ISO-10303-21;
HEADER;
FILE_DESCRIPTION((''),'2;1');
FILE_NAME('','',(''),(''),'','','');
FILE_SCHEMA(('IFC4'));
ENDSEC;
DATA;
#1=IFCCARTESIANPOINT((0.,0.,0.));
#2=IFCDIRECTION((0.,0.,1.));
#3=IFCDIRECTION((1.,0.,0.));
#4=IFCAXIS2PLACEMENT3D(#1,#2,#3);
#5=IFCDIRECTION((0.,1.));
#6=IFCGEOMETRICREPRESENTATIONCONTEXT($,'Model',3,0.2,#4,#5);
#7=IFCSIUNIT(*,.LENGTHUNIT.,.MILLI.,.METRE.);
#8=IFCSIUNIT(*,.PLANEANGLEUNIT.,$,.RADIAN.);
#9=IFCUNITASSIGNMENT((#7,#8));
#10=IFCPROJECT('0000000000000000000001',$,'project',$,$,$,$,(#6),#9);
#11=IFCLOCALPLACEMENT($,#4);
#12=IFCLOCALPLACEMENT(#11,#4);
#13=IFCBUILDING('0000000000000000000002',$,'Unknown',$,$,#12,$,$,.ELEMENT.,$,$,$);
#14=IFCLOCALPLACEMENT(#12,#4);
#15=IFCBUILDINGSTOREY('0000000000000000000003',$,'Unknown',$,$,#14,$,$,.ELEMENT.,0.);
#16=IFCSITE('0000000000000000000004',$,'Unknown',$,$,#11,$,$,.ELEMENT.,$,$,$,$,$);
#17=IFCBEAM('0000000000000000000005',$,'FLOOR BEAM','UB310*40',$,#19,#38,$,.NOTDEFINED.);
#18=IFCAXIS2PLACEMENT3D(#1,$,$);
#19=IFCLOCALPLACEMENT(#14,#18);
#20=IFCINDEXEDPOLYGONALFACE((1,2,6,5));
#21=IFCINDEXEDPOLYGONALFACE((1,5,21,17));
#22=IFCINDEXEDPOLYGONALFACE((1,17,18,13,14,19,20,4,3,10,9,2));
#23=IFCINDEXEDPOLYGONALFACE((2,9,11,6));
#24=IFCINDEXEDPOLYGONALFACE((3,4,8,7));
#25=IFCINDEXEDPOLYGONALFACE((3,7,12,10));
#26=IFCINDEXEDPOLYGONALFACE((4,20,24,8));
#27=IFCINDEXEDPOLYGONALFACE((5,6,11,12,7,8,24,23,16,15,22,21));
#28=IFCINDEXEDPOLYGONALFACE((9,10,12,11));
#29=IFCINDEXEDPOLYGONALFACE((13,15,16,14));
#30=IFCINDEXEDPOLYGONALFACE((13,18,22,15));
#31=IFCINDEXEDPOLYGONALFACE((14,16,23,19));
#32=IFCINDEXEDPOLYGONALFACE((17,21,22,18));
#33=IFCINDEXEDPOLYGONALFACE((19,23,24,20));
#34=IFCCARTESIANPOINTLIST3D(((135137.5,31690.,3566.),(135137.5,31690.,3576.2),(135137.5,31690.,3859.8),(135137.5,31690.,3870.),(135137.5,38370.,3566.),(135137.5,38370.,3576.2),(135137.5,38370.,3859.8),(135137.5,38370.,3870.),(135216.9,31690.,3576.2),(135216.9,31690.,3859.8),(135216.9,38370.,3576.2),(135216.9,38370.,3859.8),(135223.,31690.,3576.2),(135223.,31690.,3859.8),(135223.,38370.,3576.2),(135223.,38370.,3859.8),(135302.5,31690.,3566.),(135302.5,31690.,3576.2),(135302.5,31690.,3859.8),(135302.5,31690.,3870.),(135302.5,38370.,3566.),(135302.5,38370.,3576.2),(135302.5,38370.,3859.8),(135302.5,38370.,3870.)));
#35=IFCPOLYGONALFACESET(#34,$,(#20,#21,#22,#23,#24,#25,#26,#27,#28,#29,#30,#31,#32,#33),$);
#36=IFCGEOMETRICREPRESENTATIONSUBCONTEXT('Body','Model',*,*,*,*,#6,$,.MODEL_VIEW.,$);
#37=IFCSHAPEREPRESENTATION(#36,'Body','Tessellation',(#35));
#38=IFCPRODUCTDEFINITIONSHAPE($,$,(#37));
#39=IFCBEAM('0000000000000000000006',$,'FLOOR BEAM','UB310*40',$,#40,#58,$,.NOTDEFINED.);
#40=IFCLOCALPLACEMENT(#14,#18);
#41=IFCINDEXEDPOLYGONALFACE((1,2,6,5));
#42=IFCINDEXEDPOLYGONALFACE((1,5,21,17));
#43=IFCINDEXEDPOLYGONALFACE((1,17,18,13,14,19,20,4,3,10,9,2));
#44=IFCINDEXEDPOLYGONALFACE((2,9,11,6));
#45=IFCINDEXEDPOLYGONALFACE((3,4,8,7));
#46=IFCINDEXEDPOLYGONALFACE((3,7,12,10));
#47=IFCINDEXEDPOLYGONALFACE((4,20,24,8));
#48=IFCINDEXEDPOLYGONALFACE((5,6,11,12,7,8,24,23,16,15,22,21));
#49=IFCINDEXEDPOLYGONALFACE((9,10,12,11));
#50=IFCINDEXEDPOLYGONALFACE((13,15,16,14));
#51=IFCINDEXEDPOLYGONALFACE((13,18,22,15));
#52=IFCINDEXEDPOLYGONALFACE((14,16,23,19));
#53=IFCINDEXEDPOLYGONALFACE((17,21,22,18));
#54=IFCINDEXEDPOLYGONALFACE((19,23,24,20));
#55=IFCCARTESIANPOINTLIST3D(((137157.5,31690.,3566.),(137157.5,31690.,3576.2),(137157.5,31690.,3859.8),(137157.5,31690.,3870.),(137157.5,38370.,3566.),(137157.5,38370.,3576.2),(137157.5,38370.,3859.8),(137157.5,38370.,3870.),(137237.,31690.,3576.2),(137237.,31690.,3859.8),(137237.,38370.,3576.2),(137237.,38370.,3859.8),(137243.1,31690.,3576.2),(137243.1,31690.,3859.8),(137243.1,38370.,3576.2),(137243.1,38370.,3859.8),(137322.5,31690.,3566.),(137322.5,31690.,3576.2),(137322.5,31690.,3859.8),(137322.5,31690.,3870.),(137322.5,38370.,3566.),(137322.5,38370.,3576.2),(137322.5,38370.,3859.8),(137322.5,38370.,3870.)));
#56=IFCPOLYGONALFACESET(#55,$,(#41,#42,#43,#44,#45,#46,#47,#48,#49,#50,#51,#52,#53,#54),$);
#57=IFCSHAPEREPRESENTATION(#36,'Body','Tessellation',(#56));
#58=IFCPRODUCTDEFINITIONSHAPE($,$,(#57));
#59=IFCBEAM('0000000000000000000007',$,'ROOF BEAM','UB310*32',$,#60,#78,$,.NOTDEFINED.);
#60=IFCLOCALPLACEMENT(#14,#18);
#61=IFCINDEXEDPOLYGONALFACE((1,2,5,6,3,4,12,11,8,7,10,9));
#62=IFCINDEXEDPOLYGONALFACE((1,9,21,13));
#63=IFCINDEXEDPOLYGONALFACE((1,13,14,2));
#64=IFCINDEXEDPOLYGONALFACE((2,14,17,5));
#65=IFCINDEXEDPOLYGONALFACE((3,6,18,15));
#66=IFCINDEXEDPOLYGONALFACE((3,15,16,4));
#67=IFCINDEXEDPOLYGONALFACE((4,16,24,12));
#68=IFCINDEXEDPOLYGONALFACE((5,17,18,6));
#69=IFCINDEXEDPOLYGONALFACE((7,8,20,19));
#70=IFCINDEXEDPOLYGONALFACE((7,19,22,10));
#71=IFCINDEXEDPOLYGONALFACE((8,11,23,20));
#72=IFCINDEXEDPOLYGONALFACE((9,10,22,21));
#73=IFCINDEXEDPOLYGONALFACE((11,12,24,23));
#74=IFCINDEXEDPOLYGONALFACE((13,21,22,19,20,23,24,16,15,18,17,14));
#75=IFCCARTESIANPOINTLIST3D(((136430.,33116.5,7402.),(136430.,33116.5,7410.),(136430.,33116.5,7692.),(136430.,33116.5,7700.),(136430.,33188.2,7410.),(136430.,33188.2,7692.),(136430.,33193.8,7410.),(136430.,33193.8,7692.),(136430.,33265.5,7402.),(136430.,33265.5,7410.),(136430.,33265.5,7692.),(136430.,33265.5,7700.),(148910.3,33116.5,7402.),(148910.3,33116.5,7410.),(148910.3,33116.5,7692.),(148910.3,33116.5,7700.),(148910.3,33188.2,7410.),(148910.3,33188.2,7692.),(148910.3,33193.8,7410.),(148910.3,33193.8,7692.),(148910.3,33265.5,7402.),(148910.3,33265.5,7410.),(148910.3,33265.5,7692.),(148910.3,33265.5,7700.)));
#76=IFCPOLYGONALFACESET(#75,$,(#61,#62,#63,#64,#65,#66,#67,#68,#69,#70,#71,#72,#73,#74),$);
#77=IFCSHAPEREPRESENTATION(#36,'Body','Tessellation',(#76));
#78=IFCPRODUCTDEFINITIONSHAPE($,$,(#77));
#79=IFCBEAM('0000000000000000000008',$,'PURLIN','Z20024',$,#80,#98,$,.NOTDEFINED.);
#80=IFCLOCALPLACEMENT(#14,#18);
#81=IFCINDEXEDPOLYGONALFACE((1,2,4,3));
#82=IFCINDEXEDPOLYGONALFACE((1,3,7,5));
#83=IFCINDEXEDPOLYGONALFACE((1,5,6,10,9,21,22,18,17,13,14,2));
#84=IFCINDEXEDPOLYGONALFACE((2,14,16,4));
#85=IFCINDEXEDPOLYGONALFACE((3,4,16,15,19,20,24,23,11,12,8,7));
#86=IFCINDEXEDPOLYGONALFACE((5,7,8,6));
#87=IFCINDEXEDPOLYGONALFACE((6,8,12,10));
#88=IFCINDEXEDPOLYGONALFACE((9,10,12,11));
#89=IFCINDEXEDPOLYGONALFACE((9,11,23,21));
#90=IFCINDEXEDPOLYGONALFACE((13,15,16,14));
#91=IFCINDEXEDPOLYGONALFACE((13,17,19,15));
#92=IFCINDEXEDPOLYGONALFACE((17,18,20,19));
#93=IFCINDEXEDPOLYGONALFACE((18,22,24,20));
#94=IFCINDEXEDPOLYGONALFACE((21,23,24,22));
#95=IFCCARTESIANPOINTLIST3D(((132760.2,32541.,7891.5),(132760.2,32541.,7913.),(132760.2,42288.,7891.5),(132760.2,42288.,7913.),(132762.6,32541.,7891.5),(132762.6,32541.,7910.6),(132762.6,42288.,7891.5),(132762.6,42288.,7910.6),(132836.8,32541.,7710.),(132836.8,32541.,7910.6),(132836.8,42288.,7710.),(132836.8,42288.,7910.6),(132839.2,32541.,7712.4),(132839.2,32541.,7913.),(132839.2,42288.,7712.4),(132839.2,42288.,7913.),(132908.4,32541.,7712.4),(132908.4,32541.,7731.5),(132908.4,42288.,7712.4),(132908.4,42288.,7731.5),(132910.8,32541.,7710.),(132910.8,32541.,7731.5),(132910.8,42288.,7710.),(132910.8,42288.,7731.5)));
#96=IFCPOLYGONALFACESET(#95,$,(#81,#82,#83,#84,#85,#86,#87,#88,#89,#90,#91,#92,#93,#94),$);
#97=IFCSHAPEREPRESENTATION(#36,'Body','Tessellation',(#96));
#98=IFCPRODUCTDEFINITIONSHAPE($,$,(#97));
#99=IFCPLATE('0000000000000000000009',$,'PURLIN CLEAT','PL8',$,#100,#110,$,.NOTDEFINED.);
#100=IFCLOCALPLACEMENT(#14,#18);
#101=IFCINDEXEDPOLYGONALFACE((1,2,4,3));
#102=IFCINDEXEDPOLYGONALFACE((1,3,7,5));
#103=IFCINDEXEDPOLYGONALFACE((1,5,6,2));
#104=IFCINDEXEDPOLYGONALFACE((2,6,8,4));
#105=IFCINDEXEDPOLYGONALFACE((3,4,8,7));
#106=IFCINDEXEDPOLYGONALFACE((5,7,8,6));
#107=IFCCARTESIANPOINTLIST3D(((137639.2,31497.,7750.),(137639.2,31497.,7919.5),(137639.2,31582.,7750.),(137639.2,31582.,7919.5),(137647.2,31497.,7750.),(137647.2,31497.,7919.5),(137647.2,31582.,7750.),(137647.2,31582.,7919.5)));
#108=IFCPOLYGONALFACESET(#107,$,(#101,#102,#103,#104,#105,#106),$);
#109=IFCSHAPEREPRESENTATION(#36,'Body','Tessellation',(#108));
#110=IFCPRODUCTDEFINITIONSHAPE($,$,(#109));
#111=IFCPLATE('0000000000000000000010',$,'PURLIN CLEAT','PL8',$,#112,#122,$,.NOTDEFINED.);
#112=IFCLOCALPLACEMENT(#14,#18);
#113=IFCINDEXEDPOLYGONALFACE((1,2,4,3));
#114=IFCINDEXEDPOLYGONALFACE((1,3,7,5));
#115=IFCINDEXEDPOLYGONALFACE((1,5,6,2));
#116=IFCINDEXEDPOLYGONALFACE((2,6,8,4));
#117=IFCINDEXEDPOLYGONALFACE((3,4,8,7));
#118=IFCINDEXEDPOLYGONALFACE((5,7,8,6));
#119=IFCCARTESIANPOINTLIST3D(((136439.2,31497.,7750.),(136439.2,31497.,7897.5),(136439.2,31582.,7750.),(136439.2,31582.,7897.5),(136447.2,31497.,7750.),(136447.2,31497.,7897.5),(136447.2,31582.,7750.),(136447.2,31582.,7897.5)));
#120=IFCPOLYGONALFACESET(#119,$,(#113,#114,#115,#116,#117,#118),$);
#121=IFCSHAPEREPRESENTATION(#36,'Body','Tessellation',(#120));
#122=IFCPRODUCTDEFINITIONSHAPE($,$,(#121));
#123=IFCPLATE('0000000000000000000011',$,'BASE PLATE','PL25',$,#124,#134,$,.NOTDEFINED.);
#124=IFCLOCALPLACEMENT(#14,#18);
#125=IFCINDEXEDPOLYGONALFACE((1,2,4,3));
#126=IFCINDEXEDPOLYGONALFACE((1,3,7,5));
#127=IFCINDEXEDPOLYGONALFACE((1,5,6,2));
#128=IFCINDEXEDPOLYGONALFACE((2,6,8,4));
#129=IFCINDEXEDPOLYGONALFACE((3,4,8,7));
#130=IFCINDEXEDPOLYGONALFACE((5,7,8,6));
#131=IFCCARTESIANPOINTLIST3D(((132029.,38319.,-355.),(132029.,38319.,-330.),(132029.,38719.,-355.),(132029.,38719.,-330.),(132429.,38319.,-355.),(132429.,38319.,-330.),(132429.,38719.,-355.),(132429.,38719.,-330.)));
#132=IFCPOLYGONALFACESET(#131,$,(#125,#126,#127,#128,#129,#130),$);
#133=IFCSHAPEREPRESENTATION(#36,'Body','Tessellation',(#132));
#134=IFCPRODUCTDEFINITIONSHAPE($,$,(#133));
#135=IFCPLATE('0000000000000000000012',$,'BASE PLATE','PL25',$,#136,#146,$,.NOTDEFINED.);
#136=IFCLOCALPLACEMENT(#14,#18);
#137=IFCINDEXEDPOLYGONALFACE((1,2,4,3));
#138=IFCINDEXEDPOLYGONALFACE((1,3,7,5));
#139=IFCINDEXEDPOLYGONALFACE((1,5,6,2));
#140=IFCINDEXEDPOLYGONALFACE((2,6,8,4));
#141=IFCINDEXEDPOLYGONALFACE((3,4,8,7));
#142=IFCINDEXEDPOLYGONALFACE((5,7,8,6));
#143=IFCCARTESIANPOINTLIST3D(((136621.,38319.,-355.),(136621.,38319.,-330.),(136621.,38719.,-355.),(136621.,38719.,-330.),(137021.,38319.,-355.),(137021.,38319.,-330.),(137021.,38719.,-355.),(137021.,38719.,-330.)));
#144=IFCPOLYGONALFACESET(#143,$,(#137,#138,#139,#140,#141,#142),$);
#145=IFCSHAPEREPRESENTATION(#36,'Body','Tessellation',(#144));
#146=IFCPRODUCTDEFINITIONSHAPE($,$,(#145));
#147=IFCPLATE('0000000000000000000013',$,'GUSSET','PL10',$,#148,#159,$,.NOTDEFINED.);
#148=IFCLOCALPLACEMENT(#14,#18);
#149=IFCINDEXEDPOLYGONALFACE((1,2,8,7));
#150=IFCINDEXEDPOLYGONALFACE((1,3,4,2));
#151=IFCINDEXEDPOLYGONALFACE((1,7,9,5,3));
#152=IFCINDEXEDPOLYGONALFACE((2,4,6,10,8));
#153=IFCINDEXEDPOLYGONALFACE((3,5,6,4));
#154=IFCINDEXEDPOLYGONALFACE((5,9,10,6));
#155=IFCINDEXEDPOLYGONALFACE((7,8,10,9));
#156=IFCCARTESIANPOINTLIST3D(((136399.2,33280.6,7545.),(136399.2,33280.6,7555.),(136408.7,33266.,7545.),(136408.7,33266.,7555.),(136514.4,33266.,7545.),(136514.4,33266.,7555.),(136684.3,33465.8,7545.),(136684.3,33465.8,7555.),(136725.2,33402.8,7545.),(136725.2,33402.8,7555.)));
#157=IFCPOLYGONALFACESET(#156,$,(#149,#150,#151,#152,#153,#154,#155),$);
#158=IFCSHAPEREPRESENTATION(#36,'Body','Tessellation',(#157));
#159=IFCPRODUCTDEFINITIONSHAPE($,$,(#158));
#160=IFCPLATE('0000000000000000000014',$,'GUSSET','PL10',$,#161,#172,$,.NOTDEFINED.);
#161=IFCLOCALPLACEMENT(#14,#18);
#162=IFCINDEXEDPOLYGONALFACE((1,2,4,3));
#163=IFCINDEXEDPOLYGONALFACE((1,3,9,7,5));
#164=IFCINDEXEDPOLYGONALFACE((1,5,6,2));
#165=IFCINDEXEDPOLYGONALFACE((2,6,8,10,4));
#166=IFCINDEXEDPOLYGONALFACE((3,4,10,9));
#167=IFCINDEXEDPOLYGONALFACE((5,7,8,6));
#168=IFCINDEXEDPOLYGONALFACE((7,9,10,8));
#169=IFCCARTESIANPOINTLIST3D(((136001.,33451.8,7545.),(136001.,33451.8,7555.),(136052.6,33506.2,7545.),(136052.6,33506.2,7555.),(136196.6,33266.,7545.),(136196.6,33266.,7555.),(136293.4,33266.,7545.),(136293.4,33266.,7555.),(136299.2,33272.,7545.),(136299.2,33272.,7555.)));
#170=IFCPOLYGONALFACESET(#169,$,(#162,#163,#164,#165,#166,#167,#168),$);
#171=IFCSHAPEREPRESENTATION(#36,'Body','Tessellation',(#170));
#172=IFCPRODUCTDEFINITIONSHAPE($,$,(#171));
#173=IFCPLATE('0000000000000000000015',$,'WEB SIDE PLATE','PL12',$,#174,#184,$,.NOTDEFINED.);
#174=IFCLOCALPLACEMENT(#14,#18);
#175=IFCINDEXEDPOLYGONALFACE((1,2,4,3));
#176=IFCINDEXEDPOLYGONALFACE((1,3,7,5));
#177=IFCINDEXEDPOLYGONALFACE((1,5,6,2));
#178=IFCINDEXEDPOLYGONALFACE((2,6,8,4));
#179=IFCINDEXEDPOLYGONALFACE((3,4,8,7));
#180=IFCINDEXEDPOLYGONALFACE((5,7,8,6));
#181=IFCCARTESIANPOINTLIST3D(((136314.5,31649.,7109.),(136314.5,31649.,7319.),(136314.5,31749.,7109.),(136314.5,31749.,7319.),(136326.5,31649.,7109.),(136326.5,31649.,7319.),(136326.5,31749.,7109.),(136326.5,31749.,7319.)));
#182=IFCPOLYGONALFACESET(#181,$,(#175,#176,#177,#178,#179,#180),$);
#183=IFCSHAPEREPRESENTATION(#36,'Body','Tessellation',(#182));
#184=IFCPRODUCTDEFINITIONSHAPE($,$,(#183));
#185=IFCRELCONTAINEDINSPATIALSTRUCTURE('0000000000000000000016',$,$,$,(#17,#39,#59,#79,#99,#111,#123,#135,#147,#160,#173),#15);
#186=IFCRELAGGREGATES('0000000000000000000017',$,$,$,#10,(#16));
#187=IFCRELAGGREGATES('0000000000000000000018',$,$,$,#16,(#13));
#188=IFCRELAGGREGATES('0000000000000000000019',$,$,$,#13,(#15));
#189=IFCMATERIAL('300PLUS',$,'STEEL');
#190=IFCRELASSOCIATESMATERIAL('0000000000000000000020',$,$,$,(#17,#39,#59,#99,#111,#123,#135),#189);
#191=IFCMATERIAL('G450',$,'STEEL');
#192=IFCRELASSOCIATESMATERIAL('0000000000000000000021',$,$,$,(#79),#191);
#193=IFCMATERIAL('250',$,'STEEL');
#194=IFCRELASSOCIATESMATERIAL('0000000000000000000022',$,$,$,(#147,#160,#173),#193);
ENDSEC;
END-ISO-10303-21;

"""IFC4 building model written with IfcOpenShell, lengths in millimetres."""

from ifc_helpers import new_model, si_unit, direction, frame, origin_with_axes, place, context, subcontext, project, spatial, line, indexed_curve, outline, extrude, material, element, save


model = new_model("IFC4")

# Units and contexts
model_context = context("Model", 3, precision=0.2, world=origin_with_axes(), true_north=direction((0.0, 1.0)))
body_context = subcontext(model_context, "Body", "Model", "MODEL_VIEW")
ifc_project = project(units=[si_unit("LENGTHUNIT", "METRE", prefix="MILLI"), si_unit("PLANEANGLEUNIT", "RADIAN")], contexts=[model_context])

# Site, building, storey
site_placement = place(None, origin_with_axes())
site = spatial("IfcSite", under=ifc_project, at=site_placement, Name="Unknown", CompositionType="ELEMENT")
building_placement = place(site_placement, origin_with_axes())
building = spatial("IfcBuilding", under=site, at=building_placement, Name="Unknown", CompositionType="ELEMENT")
storey_placement = place(building_placement, origin_with_axes())
storey = spatial("IfcBuildingStorey", under=building, at=storey_placement, Name="Unknown", CompositionType="ELEMENT", Elevation=0.0)

# Beams
ifc_material_1 = material(Name="300PLUS", Category="STEEL")
for number, where, z_axis, x_axis, name in (
    (1, (135220.0, 31690.0, 3718.0), (1.0, 0.0, 0.0), (0.0, 1.0, 0.0), "FLOOR BEAM"),
    (2, (137240.0, 31690.0, 3718.0), (1.0, 0.0, 0.0), (0.0, 1.0, 0.0), "FLOOR BEAM"),
):
    element("IfcBeam", number, at=place(storey_placement, frame(where, z_axis=z_axis, x_axis=x_axis)), inside=storey, material=ifc_material_1, Name=name, Description="UB310*40", PredefinedType="NOTDEFINED", context=body_context, shape_type="SolidModel", body=[
        extrude(outline(indexed_curve([(-82.5, -152.0), (82.5, -152.0), (82.5, -141.8), (3.0, -141.8), (3.0, 141.8), (82.5, 141.8), (82.5, 152.0), (-82.5, 152.0), (-82.5, 141.8), (-3.0, 141.8), (-3.0, -141.8), (-82.5, -141.8)], segments=[line(1, 2, 3, 4, 5, 6, 7, 8, 9, 10, 11, 12, 1)])), frame((0.0, 0.0, 0.0), z_axis=(-1.0, 0.0, 0.0), x_axis=(0.0, 0.0, 1.0)), (0.0, 0.0, -1.0), 6680.0),
    ])
beam_1_placement = place(storey_placement, frame((136430.0, 33191.0, 7551.0), z_axis=(0.0, -1.0, 0.0), x_axis=(1.0, 0.0, 0.0)))
element("IfcBeam", 3, at=beam_1_placement, inside=storey, material=ifc_material_1, Name="ROOF BEAM", Description="UB310*32", PredefinedType="NOTDEFINED", context=body_context, shape_type="SolidModel", body=[
    extrude(outline(indexed_curve([(-74.5, -149.0), (74.5, -149.0), (74.5, -141.0), (2.8, -141.0), (2.8, 141.0), (74.5, 141.0), (74.5, 149.0), (-74.5, 149.0), (-74.5, 141.0), (-2.8, 141.0), (-2.8, -141.0), (-74.5, -141.0)], segments=[line(1, 2, 3, 4, 5, 6, 7, 8, 9, 10, 11, 12, 1)])), frame((0.0, 0.0, 0.0), z_axis=(-1.0, 0.0, 0.0), x_axis=(0.0, 0.0, 1.0)), (0.0, 0.0, -1.0), 12480.3),
])
ifc_material_2 = material(Name="G450", Category="STEEL")
beam_2_placement = place(storey_placement, frame((132838.0, 32541.0, 7811.5), z_axis=(1.0, 0.0, 0.0), x_axis=(0.0, 1.0, 0.0)))
element("IfcBeam", 4, at=beam_2_placement, inside=storey, material=ifc_material_2, Name="PURLIN", Description="Z20024", PredefinedType="NOTDEFINED", context=body_context, shape_type="SolidModel", body=[
    extrude(outline(indexed_curve([(72.8, -101.5), (72.8, -80.0), (70.4, -80.0), (70.4, -99.1), (1.2, -99.1), (1.2, 101.5), (-77.8, 101.5), (-77.8, 80.0), (-75.4, 80.0), (-75.4, 99.1), (-1.2, 99.1), (-1.2, -101.5)], segments=[line(1, 2, 3, 4, 5, 6, 7, 8, 9, 10, 11, 12, 1)])), frame((0.0, 0.0, 0.0), z_axis=(-1.0, 0.0, 0.0), x_axis=(0.0, 0.0, 1.0)), (0.0, 0.0, -1.0), 9747.0),
])

# Plates
plate_1_placement = place(storey_placement, frame((137643.2, 31497.0, 7750.0), z_axis=(1.0, 0.0, 0.0), x_axis=(0.0, 1.0, 0.0)))
element("IfcPlate", 5, at=plate_1_placement, inside=storey, material=ifc_material_1, Name="PURLIN CLEAT", Description="PL8", PredefinedType="NOTDEFINED", context=body_context, shape_type="SolidModel", body=[
    extrude(outline(indexed_curve([(0.0, 0.0), (85.0, 0.0), (85.0, 169.5), (0.0, 169.5)], segments=[line(1, 2, 3, 4, 1)])), frame((0.0, 0.0, 4.0), z_axis=(0.0, 0.0, 1.0), x_axis=(1.0, 0.0, 0.0)), (0.0, 0.0, -1.0), 8.0),
])
plate_2_placement = place(storey_placement, frame((136443.2, 31497.0, 7750.0), z_axis=(1.0, 0.0, 0.0), x_axis=(0.0, 1.0, 0.0)))
element("IfcPlate", 6, at=plate_2_placement, inside=storey, material=ifc_material_1, Name="PURLIN CLEAT", Description="PL8", PredefinedType="NOTDEFINED", context=body_context, shape_type="SolidModel", body=[
    extrude(outline(indexed_curve([(0.0, 0.0), (85.0, 0.0), (85.0, 147.5), (0.0, 147.5)], segments=[line(1, 2, 3, 4, 1)])), frame((0.0, 0.0, 4.0), z_axis=(0.0, 0.0, 1.0), x_axis=(1.0, 0.0, 0.0)), (0.0, 0.0, -1.0), 8.0),
])
for number, where, z_axis, x_axis, name in (
    (7, (132029.0, 38319.0, -342.5), (0.0, 0.0, 1.0), (1.0, 0.0, 0.0), "BASE PLATE"),
    (8, (136621.0, 38319.0, -342.5), (0.0, 0.0, 1.0), (1.0, 0.0, 0.0), "BASE PLATE"),
):
    element("IfcPlate", number, at=place(storey_placement, frame(where, z_axis=z_axis, x_axis=x_axis)), inside=storey, material=ifc_material_1, Name=name, Description="PL25", PredefinedType="NOTDEFINED", context=body_context, shape_type="SolidModel", body=[
        extrude(outline(indexed_curve([(0.0, 0.0), (400.0, 0.0), (400.0, 400.0), (0.0, 400.0)], segments=[line(1, 2, 3, 4, 1)])), frame((0.0, 0.0, 12.5), z_axis=(0.0, 0.0, 1.0), x_axis=(1.0, 0.0, 0.0)), (0.0, 0.0, -1.0), 25.0),
    ])
ifc_material_3 = material(Name="250", Category="STEEL")
plate_3_placement = place(storey_placement, frame((136514.4, 33266.0, 7550.0), z_axis=(0.0, 0.0, 1.0), x_axis=(0.838843, 0.544373, 0.0)))
element("IfcPlate", 9, at=plate_3_placement, inside=storey, material=ifc_material_3, Name="GUSSET", Description="PL10", PredefinedType="NOTDEFINED", context=body_context, shape_type="SolidModel", body=[
    extrude(outline(indexed_curve([(0.0, 0.0), (251.3, 0.0), (251.3, 75.1), (-88.7, 75.0), (-88.7, 57.5)], segments=[line(1, 2, 3, 4, 5, 1)])), frame((0.0, 0.0, 5.0), z_axis=(0.0, 0.0, 1.0), x_axis=(1.0, 0.0, 0.0)), (0.0, 0.0, -1.0), 10.0),
])
plate_4_placement = place(storey_placement, frame((136299.2, 33272.0, 7550.0), z_axis=(0.0, 0.0, 1.0), x_axis=(-0.725102, 0.688641, 0.0)))
element("IfcPlate", 10, at=plate_4_placement, inside=storey, material=ifc_material_3, Name="GUSSET", Description="PL10", PredefinedType="NOTDEFINED", context=body_context, shape_type="SolidModel", body=[
    extrude(outline(indexed_curve([(0.0, 0.0), (340.1, 0.0), (340.0, 75.0), (70.3, 75.0), (0.1, 8.3)], segments=[line(1, 2, 3, 4, 5, 1)])), frame((0.0, 0.0, 5.0), z_axis=(0.0, 0.0, 1.0), x_axis=(1.0, 0.0, 0.0)), (0.0, 0.0, -1.0), 10.0),
])
plate_5_placement = place(storey_placement, frame((136320.5, 31649.0, 7319.0), z_axis=(-1.0, 0.0, 0.0), x_axis=(0.0, 1.0, 0.0)))
element("IfcPlate", 11, at=plate_5_placement, inside=storey, material=ifc_material_3, Name="WEB SIDE PLATE", Description="PL12", PredefinedType="NOTDEFINED", context=body_context, shape_type="SolidModel", body=[
    extrude(outline(indexed_curve([(0.0, 0.0), (100.0, 0.0), (100.0, 210.0), (0.0, 210.0)], segments=[line(1, 2, 3, 4, 1)])), frame((0.0, 0.0, 6.0), z_axis=(0.0, 0.0, 1.0), x_axis=(1.0, 0.0, 0.0)), (0.0, 0.0, -1.0), 12.0),
])

save(model, "model.ifc")
